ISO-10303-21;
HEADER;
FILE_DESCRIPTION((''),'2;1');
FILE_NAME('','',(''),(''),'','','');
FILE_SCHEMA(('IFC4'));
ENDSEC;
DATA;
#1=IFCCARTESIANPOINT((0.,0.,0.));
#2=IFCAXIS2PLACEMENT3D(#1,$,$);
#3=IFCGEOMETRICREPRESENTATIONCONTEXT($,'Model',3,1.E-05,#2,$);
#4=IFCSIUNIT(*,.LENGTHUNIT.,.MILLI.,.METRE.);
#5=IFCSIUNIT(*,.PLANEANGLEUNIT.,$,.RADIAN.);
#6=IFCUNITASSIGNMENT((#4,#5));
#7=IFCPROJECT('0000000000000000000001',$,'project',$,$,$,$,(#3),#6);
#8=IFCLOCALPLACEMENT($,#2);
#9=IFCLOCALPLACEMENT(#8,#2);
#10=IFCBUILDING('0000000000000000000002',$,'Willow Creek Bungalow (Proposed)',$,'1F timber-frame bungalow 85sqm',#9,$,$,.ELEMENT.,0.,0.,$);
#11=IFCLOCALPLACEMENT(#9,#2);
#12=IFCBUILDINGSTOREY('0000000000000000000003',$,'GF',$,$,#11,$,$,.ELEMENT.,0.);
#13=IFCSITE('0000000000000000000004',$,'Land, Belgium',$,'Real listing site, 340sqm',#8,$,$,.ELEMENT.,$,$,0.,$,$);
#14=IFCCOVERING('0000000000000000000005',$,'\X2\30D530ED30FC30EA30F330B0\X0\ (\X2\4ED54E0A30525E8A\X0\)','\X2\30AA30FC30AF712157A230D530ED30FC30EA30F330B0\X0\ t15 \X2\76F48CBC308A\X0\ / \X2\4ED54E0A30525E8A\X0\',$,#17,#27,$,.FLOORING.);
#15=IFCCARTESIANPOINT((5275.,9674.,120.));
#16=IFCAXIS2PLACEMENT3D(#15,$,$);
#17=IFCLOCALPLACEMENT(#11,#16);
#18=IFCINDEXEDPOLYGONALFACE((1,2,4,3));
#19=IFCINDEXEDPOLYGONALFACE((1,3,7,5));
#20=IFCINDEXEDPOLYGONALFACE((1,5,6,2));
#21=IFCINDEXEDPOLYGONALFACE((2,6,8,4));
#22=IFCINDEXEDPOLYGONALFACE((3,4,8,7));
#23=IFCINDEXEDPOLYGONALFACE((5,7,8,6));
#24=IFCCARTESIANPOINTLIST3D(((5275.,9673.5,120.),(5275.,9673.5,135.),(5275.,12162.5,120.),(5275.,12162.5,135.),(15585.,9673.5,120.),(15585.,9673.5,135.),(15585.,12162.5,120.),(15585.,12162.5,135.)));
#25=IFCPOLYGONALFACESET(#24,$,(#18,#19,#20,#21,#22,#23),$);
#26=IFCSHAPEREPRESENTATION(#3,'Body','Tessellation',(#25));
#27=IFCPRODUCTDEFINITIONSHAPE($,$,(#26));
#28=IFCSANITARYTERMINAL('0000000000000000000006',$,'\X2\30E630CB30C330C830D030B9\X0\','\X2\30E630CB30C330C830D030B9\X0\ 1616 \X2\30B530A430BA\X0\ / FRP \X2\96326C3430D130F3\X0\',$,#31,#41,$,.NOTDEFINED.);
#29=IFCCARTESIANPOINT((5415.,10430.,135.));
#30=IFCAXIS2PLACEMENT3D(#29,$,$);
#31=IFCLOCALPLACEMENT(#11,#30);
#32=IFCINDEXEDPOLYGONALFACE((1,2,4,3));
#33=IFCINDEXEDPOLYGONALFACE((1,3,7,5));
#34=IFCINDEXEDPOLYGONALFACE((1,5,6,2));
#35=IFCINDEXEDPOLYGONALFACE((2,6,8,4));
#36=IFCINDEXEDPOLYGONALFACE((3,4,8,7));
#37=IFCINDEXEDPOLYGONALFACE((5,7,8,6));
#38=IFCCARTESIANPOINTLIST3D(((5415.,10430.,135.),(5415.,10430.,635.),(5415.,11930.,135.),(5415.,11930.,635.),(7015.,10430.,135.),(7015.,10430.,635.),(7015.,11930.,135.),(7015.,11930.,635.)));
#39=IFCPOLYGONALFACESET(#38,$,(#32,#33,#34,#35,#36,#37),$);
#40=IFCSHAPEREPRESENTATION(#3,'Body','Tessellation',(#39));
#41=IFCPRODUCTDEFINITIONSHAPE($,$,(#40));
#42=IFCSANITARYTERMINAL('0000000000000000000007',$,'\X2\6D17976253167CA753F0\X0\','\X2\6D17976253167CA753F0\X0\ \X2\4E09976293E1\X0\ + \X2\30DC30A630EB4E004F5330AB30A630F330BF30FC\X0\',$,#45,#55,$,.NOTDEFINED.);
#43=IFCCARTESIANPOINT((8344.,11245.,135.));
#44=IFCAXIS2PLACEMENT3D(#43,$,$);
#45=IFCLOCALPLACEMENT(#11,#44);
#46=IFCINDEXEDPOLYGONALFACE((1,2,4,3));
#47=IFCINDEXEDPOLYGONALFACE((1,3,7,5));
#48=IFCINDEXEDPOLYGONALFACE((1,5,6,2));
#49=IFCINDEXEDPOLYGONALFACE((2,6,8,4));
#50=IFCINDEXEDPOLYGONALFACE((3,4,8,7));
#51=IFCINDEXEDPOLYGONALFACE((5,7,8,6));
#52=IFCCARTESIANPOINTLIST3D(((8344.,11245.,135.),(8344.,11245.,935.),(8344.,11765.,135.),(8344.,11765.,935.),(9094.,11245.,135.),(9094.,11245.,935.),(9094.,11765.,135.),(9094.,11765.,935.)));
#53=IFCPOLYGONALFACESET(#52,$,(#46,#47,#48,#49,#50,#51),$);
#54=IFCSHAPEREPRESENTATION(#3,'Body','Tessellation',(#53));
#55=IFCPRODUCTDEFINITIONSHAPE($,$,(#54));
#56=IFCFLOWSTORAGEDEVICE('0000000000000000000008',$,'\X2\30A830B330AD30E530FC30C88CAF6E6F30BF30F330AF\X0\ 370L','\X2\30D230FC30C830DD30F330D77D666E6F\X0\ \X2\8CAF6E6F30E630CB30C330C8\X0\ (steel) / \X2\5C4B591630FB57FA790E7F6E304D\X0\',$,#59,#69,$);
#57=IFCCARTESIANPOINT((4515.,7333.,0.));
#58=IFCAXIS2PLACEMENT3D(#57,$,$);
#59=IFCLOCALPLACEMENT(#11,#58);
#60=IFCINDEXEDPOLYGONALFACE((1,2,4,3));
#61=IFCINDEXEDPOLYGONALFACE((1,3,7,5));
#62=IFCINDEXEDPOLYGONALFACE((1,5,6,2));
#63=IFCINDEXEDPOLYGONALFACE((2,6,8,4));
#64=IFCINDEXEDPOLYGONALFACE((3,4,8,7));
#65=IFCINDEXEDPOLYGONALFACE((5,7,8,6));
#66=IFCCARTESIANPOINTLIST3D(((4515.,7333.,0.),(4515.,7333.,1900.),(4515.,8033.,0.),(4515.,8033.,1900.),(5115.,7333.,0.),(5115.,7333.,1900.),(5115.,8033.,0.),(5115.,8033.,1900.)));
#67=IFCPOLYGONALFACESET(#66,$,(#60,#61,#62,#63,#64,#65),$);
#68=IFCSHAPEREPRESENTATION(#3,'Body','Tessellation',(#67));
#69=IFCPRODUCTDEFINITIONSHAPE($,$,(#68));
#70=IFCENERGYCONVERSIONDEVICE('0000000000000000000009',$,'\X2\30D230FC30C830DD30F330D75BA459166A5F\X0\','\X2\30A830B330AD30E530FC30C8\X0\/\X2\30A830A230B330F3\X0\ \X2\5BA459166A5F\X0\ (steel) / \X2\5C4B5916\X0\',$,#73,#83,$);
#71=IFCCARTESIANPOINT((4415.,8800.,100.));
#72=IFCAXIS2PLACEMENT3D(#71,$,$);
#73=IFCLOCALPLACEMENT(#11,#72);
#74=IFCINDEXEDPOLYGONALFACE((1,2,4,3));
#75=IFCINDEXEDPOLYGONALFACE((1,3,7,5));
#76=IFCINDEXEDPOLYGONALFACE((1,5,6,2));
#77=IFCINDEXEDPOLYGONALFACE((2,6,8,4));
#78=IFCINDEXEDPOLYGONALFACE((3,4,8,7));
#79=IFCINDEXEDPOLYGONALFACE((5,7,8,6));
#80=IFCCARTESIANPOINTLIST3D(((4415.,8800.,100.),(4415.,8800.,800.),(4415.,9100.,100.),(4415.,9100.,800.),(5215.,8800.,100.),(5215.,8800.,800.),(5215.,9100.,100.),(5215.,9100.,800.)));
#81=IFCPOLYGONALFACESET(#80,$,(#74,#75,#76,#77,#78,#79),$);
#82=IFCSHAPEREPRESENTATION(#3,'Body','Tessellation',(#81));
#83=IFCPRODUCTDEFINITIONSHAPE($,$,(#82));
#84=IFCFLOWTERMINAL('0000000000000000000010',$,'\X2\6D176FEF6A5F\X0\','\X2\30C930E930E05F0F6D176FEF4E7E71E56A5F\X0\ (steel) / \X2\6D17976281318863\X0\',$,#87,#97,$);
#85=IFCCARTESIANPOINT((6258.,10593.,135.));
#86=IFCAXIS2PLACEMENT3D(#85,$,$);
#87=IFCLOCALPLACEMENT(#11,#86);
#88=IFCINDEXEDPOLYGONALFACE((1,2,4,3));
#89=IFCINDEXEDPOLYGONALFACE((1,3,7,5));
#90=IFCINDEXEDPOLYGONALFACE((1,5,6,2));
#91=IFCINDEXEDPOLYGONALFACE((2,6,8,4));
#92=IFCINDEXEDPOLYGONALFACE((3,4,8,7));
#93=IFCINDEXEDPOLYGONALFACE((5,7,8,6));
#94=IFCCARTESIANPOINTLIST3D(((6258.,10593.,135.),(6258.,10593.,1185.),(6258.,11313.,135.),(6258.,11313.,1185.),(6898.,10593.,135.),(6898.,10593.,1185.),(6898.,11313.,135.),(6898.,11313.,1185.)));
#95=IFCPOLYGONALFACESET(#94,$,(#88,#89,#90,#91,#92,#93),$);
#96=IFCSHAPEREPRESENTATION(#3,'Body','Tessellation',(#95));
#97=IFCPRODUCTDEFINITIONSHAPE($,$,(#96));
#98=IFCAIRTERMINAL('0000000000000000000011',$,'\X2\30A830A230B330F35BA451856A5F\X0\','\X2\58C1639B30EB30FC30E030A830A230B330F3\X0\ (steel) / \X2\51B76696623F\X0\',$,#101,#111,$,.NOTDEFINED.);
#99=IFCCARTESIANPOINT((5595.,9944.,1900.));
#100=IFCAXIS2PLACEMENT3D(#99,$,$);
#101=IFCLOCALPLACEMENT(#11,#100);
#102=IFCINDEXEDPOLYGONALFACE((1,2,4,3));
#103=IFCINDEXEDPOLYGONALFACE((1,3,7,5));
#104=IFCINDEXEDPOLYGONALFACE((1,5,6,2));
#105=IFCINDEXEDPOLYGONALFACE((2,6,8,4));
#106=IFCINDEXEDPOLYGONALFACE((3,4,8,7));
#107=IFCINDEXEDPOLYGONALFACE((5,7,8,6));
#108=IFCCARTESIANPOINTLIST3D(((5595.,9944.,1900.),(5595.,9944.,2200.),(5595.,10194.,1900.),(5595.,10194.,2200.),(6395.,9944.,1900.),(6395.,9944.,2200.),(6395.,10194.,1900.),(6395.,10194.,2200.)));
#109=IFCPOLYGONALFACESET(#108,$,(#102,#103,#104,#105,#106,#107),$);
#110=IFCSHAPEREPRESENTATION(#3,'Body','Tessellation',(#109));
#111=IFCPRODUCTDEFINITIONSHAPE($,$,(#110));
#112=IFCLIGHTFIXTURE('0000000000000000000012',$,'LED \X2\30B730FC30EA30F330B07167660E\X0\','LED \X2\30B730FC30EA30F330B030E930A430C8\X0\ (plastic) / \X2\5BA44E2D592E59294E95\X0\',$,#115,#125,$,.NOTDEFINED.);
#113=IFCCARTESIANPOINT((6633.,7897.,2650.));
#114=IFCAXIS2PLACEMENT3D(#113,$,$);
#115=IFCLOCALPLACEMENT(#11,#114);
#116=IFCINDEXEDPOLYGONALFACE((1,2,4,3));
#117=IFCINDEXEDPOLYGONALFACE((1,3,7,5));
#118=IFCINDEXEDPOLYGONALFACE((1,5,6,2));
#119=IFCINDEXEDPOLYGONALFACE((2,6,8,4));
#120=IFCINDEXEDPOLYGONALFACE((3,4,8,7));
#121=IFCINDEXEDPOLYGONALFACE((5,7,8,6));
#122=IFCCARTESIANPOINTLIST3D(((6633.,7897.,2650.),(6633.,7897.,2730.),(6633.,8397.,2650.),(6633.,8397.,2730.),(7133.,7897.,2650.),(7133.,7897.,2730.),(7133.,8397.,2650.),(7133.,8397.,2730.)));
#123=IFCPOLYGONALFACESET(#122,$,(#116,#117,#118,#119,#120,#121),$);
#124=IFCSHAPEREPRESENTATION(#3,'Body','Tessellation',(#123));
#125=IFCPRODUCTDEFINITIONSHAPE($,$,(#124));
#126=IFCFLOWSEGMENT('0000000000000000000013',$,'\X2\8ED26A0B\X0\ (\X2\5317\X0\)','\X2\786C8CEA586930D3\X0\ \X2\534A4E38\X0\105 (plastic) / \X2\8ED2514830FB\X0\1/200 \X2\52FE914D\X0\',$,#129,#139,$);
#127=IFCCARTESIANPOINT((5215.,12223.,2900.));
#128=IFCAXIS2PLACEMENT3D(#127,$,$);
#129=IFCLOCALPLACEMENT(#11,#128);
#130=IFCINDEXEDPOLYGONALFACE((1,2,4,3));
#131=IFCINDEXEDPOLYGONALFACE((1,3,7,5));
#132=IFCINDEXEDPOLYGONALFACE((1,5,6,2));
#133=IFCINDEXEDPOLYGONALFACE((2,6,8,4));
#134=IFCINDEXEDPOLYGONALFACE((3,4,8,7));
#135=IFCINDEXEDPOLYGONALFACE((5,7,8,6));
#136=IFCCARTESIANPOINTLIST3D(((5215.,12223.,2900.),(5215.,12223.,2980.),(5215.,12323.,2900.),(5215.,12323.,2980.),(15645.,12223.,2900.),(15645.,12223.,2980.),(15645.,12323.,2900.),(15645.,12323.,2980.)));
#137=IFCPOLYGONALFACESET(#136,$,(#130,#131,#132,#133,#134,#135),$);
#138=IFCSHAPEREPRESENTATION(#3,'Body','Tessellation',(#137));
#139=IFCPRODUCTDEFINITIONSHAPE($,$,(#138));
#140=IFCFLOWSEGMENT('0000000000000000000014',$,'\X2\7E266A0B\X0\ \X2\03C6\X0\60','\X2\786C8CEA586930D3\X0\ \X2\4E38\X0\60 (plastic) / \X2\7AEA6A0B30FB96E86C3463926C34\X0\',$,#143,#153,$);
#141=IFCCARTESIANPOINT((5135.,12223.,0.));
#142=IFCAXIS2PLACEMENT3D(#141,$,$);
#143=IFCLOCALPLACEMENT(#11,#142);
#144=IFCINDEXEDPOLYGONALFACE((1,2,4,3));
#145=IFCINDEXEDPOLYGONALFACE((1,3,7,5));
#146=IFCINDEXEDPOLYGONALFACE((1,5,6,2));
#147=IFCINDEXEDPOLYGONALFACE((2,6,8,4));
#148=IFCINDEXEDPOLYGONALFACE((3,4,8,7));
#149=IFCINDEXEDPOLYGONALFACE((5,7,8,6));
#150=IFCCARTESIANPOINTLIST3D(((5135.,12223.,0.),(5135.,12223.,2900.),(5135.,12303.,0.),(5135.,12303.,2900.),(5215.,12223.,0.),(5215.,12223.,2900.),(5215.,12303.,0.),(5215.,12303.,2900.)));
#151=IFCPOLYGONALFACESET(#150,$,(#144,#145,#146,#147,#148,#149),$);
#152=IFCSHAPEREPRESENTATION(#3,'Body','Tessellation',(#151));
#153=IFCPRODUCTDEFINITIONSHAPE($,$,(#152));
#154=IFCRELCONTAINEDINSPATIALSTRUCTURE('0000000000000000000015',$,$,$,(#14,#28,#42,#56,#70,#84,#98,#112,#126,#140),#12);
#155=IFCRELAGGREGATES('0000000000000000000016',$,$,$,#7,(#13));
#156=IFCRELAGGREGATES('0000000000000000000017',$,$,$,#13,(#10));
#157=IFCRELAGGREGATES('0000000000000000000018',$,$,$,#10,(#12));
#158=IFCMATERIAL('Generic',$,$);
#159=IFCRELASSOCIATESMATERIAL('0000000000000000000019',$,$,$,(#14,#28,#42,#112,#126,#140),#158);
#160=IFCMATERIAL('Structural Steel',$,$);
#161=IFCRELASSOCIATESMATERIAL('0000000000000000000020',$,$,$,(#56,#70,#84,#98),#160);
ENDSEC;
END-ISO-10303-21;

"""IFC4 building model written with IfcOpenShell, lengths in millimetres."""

from ifc_helpers import new_model, si_unit, frame, frame_2d, origin, place, context, project, spatial, rectangle, extrude, material, element, save


model = new_model("IFC4")

# Units and contexts
model_context = context("Model", 3, precision=1e-05, world=origin())
ifc_project = project(units=[si_unit("LENGTHUNIT", "METRE", prefix="MILLI"), si_unit("PLANEANGLEUNIT", "RADIAN")], contexts=[model_context])

# Site, building, storey
site_placement = place(None, origin())
site = spatial("IfcSite", under=ifc_project, at=site_placement, Name="Land, Belgium", ObjectType="Real listing site, 340sqm", CompositionType="ELEMENT", RefElevation=0.0)
building_placement = place(site_placement, origin())
building = spatial("IfcBuilding", under=site, at=building_placement, Name="Willow Creek Bungalow (Proposed)", ObjectType="1F timber-frame bungalow 85sqm", CompositionType="ELEMENT", ElevationOfRefHeight=0.0, ElevationOfTerrain=0.0)
storey_placement = place(building_placement, origin())
storey = spatial("IfcBuildingStorey", under=building, at=storey_placement, Name="GF", CompositionType="ELEMENT", Elevation=0.0)

# Shared definitions
ifc_material_1 = material(Name="Structural Steel")

# Covering
ifc_material_2 = material(Name="Generic")
covering_1_placement = place(storey_placement, frame((5275.0, 9674.0, 120.0)))
element("IfcCovering", 1, at=covering_1_placement, inside=storey, material=ifc_material_2, Name="フローリング (仕上げ床)", Description="オーク無垢フローリング t15 直貼り / 仕上げ床", PredefinedType="FLOORING", context=model_context, shape_type="SweptSolid", body=[
    extrude(rectangle(XDim=10310.0, YDim=2489.0, at=frame_2d((5155.0, 1244.0))), frame((5275.0, 9674.0, 120.0)), (0.0, 0.0, 1.0), 15.0),
])

# Sanitary terminals
sanitary_terminal_1_placement = place(storey_placement, frame((5415.0, 10430.0, 135.0)))
element("IfcSanitaryTerminal", 2, at=sanitary_terminal_1_placement, inside=storey, material=ifc_material_2, Name="ユニットバス", Description="ユニットバス 1616 サイズ / FRP 防水パン", PredefinedType="NOTDEFINED", context=model_context, shape_type="SweptSolid", body=[
    extrude(rectangle(XDim=1600.0, YDim=1500.0, at=frame_2d((800.0, 750.0))), frame((5415.0, 10430.0, 135.0)), (0.0, 0.0, 1.0), 500.0),
])
sanitary_terminal_2_placement = place(storey_placement, frame((8344.0, 11245.0, 135.0)))
element("IfcSanitaryTerminal", 3, at=sanitary_terminal_2_placement, inside=storey, material=ifc_material_2, Name="洗面化粧台", Description="洗面化粧台 三面鏡 + ボウル一体カウンター", PredefinedType="NOTDEFINED", context=model_context, shape_type="SweptSolid", body=[
    extrude(rectangle(XDim=750.0, YDim=520.0, at=frame_2d((375.0, 260.0))), frame((8344.0, 11245.0, 135.0)), (0.0, 0.0, 1.0), 800.0),
])

# Flow storage device
flow_storage_device_placement = place(storey_placement, frame((4515.0, 7333.0, 0.0)))
element("IfcFlowStorageDevice", 4, at=flow_storage_device_placement, inside=storey, material=ifc_material_1, Name="エコキュート貯湯タンク 370L", Description="ヒートポンプ給湯 貯湯ユニット (steel) / 屋外・基礎置き", context=model_context, shape_type="SweptSolid", body=[
    extrude(rectangle(XDim=600.0, YDim=700.0, at=frame_2d((300.0, 350.0))), frame((4515.0, 7333.0, 0.0)), (0.0, 0.0, 1.0), 1900.0),
])

# Energy conversion device
energy_conversion_device_placement = place(storey_placement, frame((4415.0, 8800.0, 100.0)))
element("IfcEnergyConversionDevice", 5, at=energy_conversion_device_placement, inside=storey, material=ifc_material_1, Name="ヒートポンプ室外機", Description="エコキュート/エアコン 室外機 (steel) / 屋外", context=model_context, shape_type="SweptSolid", body=[
    extrude(rectangle(XDim=800.0, YDim=300.0, at=frame_2d((400.0, 150.0))), frame((4415.0, 8800.0, 100.0)), (0.0, 0.0, 1.0), 700.0),
])

# Flow terminal
flow_terminal_placement = place(storey_placement, frame((6258.0, 10593.0, 135.0)))
element("IfcFlowTerminal", 6, at=flow_terminal_placement, inside=storey, material=ifc_material_1, Name="洗濯機", Description="ドラム式洗濯乾燥機 (steel) / 洗面脱衣", context=model_context, shape_type="SweptSolid", body=[
    extrude(rectangle(XDim=640.0, YDim=720.0, at=frame_2d((320.0, 360.0))), frame((6258.0, 10593.0, 135.0)), (0.0, 0.0, 1.0), 1050.0),
])

# Air terminal
air_terminal_placement = place(storey_placement, frame((5595.0, 9944.0, 1900.0)))
element("IfcAirTerminal", 7, at=air_terminal_placement, inside=storey, material=ifc_material_1, Name="エアコン室内機", Description="壁掛ルームエアコン (steel) / 冷暖房", PredefinedType="NOTDEFINED", context=model_context, shape_type="SweptSolid", body=[
    extrude(rectangle(XDim=800.0, YDim=250.0, at=frame_2d((400.0, 125.0))), frame((5595.0, 9944.0, 1900.0)), (0.0, 0.0, 1.0), 300.0),
])

# Light fixture
light_fixture_placement = place(storey_placement, frame((6633.0, 7897.0, 2650.0)))
element("IfcLightFixture", 8, at=light_fixture_placement, inside=storey, material=ifc_material_2, Name="LED シーリング照明", Description="LED シーリングライト (plastic) / 室中央天井", PredefinedType="NOTDEFINED", context=model_context, shape_type="SweptSolid", body=[
    extrude(rectangle(XDim=500.0, YDim=500.0, at=frame_2d((250.0, 250.0))), frame((6633.0, 7897.0, 2650.0)), (0.0, 0.0, 1.0), 80.0),
])

# Flow segments
flow_segment_1_placement = place(storey_placement, frame((5215.0, 12223.0, 2900.0)))
element("IfcFlowSegment", 9, at=flow_segment_1_placement, inside=storey, material=ifc_material_2, Name="軒樋 (北)", Description="硬質塩ビ 半丸105 (plastic) / 軒先・1/200 勾配", context=model_context, shape_type="SweptSolid", body=[
    extrude(rectangle(XDim=10430.0, YDim=100.0, at=frame_2d((5215.0, 50.0))), frame((5215.0, 12223.0, 2900.0)), (0.0, 0.0, 1.0), 80.0),
])
flow_segment_2_placement = place(storey_placement, frame((5135.0, 12223.0, 0.0)))
element("IfcFlowSegment", 10, at=flow_segment_2_placement, inside=storey, material=ifc_material_2, Name="縦樋 φ60", Description="硬質塩ビ 丸60 (plastic) / 竪樋・雨水排水", context=model_context, shape_type="SweptSolid", body=[
    extrude(rectangle(XDim=80.0, YDim=80.0, at=frame_2d((40.0, 40.0))), frame((5135.0, 12223.0, 0.0)), (0.0, 0.0, 1.0), 2900.0),
])

save(model, "model.ifc")
